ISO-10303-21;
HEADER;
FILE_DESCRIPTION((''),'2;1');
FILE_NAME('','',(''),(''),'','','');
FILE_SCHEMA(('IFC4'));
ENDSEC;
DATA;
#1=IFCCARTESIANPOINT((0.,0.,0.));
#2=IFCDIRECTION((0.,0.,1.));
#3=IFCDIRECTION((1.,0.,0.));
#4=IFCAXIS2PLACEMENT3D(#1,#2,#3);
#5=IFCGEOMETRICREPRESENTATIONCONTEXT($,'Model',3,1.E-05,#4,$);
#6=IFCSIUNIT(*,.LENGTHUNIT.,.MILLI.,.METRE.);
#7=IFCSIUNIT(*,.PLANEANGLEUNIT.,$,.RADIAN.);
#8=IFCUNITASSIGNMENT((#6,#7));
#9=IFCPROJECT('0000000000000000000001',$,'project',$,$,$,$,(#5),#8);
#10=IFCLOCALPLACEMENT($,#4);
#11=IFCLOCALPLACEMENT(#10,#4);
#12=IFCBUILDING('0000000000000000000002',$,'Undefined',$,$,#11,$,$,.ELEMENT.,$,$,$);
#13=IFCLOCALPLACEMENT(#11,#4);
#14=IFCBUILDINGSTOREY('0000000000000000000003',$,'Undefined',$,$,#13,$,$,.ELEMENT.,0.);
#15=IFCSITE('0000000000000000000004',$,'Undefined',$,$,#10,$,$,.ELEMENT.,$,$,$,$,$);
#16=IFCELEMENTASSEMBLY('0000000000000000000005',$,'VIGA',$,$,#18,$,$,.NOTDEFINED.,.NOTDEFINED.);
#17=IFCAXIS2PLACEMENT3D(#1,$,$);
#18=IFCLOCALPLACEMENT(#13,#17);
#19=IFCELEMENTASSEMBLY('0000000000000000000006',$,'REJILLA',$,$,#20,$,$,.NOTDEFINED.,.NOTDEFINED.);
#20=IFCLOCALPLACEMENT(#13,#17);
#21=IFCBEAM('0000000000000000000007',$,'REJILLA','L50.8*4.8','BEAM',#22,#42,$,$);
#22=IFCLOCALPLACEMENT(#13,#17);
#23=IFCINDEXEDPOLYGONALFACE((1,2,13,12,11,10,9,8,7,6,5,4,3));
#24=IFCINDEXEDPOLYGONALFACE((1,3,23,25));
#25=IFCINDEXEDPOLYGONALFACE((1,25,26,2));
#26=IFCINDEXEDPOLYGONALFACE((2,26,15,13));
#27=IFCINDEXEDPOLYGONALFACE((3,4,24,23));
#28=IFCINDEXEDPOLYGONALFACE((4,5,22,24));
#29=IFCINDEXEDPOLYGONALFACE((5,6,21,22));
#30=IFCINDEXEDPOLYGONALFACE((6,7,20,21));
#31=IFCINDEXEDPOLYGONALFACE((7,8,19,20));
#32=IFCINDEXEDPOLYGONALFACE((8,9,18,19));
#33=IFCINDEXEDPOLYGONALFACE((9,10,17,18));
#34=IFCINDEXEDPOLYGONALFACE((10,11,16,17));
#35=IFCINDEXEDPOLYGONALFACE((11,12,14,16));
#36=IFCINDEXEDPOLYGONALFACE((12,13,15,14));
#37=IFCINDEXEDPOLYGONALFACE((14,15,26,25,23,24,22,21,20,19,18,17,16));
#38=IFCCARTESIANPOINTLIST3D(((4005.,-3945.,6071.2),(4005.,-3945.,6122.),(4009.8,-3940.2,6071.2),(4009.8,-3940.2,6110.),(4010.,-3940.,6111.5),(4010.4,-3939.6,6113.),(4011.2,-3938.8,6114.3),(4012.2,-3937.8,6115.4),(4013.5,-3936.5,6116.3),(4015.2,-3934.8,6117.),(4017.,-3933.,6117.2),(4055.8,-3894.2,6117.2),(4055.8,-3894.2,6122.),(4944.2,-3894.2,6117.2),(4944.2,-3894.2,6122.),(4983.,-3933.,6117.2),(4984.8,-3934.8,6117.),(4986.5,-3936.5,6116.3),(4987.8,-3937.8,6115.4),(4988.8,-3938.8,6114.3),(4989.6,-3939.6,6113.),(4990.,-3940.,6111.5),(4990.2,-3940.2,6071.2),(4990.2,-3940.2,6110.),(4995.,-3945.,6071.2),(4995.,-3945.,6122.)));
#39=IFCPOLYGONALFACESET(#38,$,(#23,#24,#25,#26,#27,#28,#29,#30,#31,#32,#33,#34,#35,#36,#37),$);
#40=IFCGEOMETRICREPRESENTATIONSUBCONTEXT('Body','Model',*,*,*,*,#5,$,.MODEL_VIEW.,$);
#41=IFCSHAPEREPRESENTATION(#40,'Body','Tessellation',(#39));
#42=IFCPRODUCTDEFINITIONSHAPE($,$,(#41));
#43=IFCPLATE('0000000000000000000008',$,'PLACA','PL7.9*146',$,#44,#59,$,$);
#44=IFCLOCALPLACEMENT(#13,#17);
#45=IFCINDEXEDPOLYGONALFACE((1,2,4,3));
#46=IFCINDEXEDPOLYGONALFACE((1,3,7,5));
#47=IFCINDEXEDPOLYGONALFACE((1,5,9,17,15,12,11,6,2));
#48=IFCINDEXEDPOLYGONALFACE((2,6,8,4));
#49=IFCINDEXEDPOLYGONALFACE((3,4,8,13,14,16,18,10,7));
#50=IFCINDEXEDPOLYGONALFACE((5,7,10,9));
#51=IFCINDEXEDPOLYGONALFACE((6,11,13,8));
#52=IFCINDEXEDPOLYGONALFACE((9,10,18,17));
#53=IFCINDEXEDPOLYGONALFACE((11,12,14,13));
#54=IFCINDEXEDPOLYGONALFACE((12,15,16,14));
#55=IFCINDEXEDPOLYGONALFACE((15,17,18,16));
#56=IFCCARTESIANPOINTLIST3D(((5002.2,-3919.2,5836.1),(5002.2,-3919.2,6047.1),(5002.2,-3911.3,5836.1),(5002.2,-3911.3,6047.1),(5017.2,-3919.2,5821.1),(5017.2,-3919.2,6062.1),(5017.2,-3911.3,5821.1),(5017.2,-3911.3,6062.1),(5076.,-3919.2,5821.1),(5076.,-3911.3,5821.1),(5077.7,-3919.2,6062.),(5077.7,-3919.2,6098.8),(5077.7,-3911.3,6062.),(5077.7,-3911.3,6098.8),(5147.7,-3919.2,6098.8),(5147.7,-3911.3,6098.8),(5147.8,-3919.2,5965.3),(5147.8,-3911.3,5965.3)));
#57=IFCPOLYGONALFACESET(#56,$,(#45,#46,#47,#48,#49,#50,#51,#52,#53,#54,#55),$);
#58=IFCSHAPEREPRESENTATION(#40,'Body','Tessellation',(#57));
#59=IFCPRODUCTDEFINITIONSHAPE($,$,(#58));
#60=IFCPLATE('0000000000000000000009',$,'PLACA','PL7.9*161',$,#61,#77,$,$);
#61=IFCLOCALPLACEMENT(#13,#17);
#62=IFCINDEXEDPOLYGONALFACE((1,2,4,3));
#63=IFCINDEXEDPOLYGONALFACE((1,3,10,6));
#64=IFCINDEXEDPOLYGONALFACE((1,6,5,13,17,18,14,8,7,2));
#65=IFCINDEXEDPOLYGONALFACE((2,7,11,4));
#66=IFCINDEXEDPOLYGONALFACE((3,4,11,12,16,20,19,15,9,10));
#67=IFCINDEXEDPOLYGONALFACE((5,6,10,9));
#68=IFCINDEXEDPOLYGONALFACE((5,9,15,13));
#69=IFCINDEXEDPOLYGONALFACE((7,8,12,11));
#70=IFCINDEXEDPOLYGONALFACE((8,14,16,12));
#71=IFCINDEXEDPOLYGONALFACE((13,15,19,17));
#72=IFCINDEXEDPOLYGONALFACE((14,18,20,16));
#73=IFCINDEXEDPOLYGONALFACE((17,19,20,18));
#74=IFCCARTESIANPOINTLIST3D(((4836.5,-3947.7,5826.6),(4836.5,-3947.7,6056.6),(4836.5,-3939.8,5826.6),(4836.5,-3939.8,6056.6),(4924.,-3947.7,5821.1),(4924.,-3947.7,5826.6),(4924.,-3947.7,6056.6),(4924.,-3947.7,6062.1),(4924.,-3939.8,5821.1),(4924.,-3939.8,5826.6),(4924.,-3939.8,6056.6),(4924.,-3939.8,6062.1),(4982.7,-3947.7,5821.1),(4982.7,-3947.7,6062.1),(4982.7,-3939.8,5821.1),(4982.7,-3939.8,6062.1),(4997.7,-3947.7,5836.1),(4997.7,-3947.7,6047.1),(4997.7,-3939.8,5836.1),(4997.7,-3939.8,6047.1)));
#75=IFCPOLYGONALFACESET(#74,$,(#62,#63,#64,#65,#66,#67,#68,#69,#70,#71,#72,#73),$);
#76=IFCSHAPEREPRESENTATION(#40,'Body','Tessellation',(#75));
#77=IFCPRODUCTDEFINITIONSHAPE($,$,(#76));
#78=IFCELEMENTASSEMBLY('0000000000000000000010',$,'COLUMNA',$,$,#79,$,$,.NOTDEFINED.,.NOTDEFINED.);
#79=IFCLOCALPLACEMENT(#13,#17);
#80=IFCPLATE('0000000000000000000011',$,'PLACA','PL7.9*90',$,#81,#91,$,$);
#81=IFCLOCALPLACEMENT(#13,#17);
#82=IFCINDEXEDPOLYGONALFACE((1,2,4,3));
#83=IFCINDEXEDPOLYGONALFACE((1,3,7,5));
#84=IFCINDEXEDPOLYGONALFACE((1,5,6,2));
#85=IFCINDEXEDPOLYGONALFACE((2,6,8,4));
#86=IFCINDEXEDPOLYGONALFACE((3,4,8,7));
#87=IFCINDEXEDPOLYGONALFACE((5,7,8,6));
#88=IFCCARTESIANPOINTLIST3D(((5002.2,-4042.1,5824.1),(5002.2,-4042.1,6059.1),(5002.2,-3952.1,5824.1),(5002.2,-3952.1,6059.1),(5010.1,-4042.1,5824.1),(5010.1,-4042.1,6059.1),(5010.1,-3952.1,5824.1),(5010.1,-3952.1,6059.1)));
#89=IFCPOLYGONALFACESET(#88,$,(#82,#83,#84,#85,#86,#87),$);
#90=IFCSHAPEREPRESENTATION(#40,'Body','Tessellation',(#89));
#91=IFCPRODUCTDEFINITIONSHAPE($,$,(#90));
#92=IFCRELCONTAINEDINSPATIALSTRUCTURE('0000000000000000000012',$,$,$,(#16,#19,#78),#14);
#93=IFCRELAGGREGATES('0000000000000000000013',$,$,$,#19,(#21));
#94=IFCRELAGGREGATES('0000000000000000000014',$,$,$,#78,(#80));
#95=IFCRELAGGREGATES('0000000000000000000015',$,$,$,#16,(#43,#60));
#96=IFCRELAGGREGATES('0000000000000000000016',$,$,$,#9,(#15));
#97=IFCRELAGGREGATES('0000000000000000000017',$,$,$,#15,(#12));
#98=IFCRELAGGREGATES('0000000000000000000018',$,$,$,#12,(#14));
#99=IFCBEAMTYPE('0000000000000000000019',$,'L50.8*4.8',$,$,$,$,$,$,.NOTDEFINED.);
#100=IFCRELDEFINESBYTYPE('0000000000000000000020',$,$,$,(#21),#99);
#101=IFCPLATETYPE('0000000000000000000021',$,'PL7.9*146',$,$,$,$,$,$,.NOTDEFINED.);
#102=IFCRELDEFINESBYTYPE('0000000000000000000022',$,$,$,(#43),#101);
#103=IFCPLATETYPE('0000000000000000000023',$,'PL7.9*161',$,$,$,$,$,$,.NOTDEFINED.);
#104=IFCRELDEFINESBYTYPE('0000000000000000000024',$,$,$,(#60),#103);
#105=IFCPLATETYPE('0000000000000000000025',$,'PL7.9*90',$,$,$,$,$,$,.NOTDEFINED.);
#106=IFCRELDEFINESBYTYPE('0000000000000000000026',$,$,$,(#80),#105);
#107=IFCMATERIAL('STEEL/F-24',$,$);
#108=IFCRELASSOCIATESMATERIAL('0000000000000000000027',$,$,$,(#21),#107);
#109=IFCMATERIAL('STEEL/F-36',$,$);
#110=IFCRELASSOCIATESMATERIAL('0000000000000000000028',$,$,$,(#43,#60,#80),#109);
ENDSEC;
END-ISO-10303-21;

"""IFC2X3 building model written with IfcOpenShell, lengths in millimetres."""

from ifc_helpers import new_model, si_unit, frame, origin_with_axes, origin_2d_with_axis, place, context, subcontext, project, spatial, polyline, l_section, outline, extrude, clip, halfspace, material, type_object, element, aggregate, save


model = new_model("IFC2X3")

# Units and contexts
model_context = context("Model", 3, precision=1e-05, world=origin_with_axes())
body_context = subcontext(model_context, "Body", "Model", "MODEL_VIEW")
ifc_project = project(units=[si_unit("LENGTHUNIT", "METRE", prefix="MILLI"), si_unit("PLANEANGLEUNIT", "RADIAN")], contexts=[model_context])

# Site, building, storey
site_placement = place(None, origin_with_axes())
site = spatial("IfcSite", under=ifc_project, at=site_placement, Name="Undefined", CompositionType="ELEMENT")
building_placement = place(site_placement, origin_with_axes())
building = spatial("IfcBuilding", under=site, at=building_placement, Name="Undefined", CompositionType="ELEMENT")
storey_placement = place(building_placement, origin_with_axes())
storey = spatial("IfcBuildingStorey", under=building, at=storey_placement, Name="Undefined", CompositionType="ELEMENT", Elevation=0.0)

# Shared definitions
ifc_material_1 = material(Name="STEEL/F-36")
ifc_material_2 = material(Name="STEEL/F-24")

# Element assembly
assembly_1_placement = place(storey_placement, origin_with_axes())
assembly_1 = element("IfcElementAssembly", 1, at=assembly_1_placement, inside=storey, Name="VIGA", AssemblyPlace="NOTDEFINED", PredefinedType="NOTDEFINED")

# Element assembly
assembly_2_placement = place(storey_placement, origin_with_axes())
assembly_2 = element("IfcElementAssembly", 2, at=assembly_2_placement, inside=storey, Name="REJILLA", AssemblyPlace="NOTDEFINED", PredefinedType="NOTDEFINED")

# Beam
beam_type_1 = type_object("IfcBeamType", Name="L50.8*4.8", PredefinedType="NOTDEFINED")
beam_1_placement = place(assembly_2_placement, frame((4005.0, -3919.6, 6096.6), z_axis=(0.0, 0.0, -1.0), x_axis=(1.0, 0.0, 0.0)))
beam_1 = element("IfcBeam", 3, at=beam_1_placement, type_object=beam_type_1, material=ifc_material_2, Name="REJILLA", Description="L50.8*4.8", ObjectType="BEAM", context=body_context, shape_type="Clipping", body=[
    clip(clip(extrude(l_section(Depth=50.8, Width=50.8, Thickness=4.8, FilletRadius=7.2, at=origin_2d_with_axis()), frame((1015.9, 0.0, 0.0), z_axis=(-1.0, 0.0, 0.0), x_axis=(0.0, -1.0, 0.0)), (0.0, 0.0, 1.0), 1041.8), halfspace(frame((939.2, -25.4, 0.0), z_axis=(-0.707107, 0.707107, 0.0), x_axis=(0.0, 0.0, -1.0)), True)), halfspace(frame((50.8, -25.4, 0.0), z_axis=(-0.707107, -0.707107, 0.0), x_axis=(0.0, 0.0, -1.0)), False)),
])
aggregate(assembly_2, [beam_1])

# Plates
plate_type_1 = type_object("IfcPlateType", Name="PL7.9*146", PredefinedType="NOTDEFINED")
plate_1_placement = place(assembly_1_placement, frame((5002.2, -3915.3, 6062.1), z_axis=(0.0, 1.0, 0.0), x_axis=(0.999999, 0.0, -0.001325)))
plate_1 = element("IfcPlate", 4, at=plate_1_placement, type_object=plate_type_1, material=ifc_material_1, Name="PLACA", Description="PL7.9*146", context=body_context, shape_type="SweptSolid", body=[
    extrude(outline(polyline([(0.0, 15.0), (15.0, 0.0), (75.5, 0.0), (75.4, -36.8), (145.4, -36.9), (145.7, 96.6), (74.1, 240.9), (15.3, 241.0), (0.3, 226.0), (0.0, 15.0)])), frame((0.0, 0.0, -4.0), z_axis=(0.0, 0.0, 1.0), x_axis=(1.0, 0.0, 0.0)), (0.0, 0.0, 1.0), 7.9),
])
plate_type_2 = type_object("IfcPlateType", Name="PL7.9*161", PredefinedType="NOTDEFINED")
plate_2_placement = place(assembly_1_placement, frame((4997.7, -3943.8, 6062.1), z_axis=(0.0, -1.0, 0.0), x_axis=(-1.0, 0.0, 0.0)))
plate_2 = element("IfcPlate", 5, at=plate_2_placement, type_object=plate_type_2, material=ifc_material_1, Name="PLACA", Description="PL7.9*161", context=body_context, shape_type="SweptSolid", body=[
    extrude(outline(polyline([(0.0, 15.0), (15.0, 0.0), (73.7, 0.0), (73.7, 5.5), (161.2, 5.5), (161.2, 235.5), (73.7, 235.5), (73.7, 241.0), (15.0, 241.0), (0.0, 226.0), (0.0, 15.0)])), frame((0.0, 0.0, -4.0), z_axis=(0.0, 0.0, 1.0), x_axis=(1.0, 0.0, 0.0)), (0.0, 0.0, 1.0), 7.9),
])

# Element assembly, plate
assembly_3_placement = place(storey_placement, origin_with_axes())
assembly_3 = element("IfcElementAssembly", 6, at=assembly_3_placement, inside=storey, Name="COLUMNA", AssemblyPlace="NOTDEFINED", PredefinedType="NOTDEFINED")
plate_type_3 = type_object("IfcPlateType", Name="PL7.9*90", PredefinedType="NOTDEFINED")
plate_3_placement = place(assembly_3_placement, frame((5006.2, -3952.1, 6059.1), z_axis=(-1.0, 0.0, 0.0), x_axis=(0.0, 0.0, -1.0)))
plate_3 = element("IfcPlate", 7, at=plate_3_placement, type_object=plate_type_3, material=ifc_material_1, Name="PLACA", Description="PL7.9*90", context=body_context, shape_type="SweptSolid", body=[
    extrude(outline(polyline([(0.0, 0.0), (235.0, 0.0), (235.0, 90.0), (0.0, 90.0), (0.0, 0.0)])), frame((0.0, 0.0, -4.0), z_axis=(0.0, 0.0, 1.0), x_axis=(1.0, 0.0, 0.0)), (0.0, 0.0, 1.0), 7.9),
])
aggregate(assembly_3, [plate_3])

aggregate(assembly_1, [plate_1, plate_2])

save(model, "model.ifc")
